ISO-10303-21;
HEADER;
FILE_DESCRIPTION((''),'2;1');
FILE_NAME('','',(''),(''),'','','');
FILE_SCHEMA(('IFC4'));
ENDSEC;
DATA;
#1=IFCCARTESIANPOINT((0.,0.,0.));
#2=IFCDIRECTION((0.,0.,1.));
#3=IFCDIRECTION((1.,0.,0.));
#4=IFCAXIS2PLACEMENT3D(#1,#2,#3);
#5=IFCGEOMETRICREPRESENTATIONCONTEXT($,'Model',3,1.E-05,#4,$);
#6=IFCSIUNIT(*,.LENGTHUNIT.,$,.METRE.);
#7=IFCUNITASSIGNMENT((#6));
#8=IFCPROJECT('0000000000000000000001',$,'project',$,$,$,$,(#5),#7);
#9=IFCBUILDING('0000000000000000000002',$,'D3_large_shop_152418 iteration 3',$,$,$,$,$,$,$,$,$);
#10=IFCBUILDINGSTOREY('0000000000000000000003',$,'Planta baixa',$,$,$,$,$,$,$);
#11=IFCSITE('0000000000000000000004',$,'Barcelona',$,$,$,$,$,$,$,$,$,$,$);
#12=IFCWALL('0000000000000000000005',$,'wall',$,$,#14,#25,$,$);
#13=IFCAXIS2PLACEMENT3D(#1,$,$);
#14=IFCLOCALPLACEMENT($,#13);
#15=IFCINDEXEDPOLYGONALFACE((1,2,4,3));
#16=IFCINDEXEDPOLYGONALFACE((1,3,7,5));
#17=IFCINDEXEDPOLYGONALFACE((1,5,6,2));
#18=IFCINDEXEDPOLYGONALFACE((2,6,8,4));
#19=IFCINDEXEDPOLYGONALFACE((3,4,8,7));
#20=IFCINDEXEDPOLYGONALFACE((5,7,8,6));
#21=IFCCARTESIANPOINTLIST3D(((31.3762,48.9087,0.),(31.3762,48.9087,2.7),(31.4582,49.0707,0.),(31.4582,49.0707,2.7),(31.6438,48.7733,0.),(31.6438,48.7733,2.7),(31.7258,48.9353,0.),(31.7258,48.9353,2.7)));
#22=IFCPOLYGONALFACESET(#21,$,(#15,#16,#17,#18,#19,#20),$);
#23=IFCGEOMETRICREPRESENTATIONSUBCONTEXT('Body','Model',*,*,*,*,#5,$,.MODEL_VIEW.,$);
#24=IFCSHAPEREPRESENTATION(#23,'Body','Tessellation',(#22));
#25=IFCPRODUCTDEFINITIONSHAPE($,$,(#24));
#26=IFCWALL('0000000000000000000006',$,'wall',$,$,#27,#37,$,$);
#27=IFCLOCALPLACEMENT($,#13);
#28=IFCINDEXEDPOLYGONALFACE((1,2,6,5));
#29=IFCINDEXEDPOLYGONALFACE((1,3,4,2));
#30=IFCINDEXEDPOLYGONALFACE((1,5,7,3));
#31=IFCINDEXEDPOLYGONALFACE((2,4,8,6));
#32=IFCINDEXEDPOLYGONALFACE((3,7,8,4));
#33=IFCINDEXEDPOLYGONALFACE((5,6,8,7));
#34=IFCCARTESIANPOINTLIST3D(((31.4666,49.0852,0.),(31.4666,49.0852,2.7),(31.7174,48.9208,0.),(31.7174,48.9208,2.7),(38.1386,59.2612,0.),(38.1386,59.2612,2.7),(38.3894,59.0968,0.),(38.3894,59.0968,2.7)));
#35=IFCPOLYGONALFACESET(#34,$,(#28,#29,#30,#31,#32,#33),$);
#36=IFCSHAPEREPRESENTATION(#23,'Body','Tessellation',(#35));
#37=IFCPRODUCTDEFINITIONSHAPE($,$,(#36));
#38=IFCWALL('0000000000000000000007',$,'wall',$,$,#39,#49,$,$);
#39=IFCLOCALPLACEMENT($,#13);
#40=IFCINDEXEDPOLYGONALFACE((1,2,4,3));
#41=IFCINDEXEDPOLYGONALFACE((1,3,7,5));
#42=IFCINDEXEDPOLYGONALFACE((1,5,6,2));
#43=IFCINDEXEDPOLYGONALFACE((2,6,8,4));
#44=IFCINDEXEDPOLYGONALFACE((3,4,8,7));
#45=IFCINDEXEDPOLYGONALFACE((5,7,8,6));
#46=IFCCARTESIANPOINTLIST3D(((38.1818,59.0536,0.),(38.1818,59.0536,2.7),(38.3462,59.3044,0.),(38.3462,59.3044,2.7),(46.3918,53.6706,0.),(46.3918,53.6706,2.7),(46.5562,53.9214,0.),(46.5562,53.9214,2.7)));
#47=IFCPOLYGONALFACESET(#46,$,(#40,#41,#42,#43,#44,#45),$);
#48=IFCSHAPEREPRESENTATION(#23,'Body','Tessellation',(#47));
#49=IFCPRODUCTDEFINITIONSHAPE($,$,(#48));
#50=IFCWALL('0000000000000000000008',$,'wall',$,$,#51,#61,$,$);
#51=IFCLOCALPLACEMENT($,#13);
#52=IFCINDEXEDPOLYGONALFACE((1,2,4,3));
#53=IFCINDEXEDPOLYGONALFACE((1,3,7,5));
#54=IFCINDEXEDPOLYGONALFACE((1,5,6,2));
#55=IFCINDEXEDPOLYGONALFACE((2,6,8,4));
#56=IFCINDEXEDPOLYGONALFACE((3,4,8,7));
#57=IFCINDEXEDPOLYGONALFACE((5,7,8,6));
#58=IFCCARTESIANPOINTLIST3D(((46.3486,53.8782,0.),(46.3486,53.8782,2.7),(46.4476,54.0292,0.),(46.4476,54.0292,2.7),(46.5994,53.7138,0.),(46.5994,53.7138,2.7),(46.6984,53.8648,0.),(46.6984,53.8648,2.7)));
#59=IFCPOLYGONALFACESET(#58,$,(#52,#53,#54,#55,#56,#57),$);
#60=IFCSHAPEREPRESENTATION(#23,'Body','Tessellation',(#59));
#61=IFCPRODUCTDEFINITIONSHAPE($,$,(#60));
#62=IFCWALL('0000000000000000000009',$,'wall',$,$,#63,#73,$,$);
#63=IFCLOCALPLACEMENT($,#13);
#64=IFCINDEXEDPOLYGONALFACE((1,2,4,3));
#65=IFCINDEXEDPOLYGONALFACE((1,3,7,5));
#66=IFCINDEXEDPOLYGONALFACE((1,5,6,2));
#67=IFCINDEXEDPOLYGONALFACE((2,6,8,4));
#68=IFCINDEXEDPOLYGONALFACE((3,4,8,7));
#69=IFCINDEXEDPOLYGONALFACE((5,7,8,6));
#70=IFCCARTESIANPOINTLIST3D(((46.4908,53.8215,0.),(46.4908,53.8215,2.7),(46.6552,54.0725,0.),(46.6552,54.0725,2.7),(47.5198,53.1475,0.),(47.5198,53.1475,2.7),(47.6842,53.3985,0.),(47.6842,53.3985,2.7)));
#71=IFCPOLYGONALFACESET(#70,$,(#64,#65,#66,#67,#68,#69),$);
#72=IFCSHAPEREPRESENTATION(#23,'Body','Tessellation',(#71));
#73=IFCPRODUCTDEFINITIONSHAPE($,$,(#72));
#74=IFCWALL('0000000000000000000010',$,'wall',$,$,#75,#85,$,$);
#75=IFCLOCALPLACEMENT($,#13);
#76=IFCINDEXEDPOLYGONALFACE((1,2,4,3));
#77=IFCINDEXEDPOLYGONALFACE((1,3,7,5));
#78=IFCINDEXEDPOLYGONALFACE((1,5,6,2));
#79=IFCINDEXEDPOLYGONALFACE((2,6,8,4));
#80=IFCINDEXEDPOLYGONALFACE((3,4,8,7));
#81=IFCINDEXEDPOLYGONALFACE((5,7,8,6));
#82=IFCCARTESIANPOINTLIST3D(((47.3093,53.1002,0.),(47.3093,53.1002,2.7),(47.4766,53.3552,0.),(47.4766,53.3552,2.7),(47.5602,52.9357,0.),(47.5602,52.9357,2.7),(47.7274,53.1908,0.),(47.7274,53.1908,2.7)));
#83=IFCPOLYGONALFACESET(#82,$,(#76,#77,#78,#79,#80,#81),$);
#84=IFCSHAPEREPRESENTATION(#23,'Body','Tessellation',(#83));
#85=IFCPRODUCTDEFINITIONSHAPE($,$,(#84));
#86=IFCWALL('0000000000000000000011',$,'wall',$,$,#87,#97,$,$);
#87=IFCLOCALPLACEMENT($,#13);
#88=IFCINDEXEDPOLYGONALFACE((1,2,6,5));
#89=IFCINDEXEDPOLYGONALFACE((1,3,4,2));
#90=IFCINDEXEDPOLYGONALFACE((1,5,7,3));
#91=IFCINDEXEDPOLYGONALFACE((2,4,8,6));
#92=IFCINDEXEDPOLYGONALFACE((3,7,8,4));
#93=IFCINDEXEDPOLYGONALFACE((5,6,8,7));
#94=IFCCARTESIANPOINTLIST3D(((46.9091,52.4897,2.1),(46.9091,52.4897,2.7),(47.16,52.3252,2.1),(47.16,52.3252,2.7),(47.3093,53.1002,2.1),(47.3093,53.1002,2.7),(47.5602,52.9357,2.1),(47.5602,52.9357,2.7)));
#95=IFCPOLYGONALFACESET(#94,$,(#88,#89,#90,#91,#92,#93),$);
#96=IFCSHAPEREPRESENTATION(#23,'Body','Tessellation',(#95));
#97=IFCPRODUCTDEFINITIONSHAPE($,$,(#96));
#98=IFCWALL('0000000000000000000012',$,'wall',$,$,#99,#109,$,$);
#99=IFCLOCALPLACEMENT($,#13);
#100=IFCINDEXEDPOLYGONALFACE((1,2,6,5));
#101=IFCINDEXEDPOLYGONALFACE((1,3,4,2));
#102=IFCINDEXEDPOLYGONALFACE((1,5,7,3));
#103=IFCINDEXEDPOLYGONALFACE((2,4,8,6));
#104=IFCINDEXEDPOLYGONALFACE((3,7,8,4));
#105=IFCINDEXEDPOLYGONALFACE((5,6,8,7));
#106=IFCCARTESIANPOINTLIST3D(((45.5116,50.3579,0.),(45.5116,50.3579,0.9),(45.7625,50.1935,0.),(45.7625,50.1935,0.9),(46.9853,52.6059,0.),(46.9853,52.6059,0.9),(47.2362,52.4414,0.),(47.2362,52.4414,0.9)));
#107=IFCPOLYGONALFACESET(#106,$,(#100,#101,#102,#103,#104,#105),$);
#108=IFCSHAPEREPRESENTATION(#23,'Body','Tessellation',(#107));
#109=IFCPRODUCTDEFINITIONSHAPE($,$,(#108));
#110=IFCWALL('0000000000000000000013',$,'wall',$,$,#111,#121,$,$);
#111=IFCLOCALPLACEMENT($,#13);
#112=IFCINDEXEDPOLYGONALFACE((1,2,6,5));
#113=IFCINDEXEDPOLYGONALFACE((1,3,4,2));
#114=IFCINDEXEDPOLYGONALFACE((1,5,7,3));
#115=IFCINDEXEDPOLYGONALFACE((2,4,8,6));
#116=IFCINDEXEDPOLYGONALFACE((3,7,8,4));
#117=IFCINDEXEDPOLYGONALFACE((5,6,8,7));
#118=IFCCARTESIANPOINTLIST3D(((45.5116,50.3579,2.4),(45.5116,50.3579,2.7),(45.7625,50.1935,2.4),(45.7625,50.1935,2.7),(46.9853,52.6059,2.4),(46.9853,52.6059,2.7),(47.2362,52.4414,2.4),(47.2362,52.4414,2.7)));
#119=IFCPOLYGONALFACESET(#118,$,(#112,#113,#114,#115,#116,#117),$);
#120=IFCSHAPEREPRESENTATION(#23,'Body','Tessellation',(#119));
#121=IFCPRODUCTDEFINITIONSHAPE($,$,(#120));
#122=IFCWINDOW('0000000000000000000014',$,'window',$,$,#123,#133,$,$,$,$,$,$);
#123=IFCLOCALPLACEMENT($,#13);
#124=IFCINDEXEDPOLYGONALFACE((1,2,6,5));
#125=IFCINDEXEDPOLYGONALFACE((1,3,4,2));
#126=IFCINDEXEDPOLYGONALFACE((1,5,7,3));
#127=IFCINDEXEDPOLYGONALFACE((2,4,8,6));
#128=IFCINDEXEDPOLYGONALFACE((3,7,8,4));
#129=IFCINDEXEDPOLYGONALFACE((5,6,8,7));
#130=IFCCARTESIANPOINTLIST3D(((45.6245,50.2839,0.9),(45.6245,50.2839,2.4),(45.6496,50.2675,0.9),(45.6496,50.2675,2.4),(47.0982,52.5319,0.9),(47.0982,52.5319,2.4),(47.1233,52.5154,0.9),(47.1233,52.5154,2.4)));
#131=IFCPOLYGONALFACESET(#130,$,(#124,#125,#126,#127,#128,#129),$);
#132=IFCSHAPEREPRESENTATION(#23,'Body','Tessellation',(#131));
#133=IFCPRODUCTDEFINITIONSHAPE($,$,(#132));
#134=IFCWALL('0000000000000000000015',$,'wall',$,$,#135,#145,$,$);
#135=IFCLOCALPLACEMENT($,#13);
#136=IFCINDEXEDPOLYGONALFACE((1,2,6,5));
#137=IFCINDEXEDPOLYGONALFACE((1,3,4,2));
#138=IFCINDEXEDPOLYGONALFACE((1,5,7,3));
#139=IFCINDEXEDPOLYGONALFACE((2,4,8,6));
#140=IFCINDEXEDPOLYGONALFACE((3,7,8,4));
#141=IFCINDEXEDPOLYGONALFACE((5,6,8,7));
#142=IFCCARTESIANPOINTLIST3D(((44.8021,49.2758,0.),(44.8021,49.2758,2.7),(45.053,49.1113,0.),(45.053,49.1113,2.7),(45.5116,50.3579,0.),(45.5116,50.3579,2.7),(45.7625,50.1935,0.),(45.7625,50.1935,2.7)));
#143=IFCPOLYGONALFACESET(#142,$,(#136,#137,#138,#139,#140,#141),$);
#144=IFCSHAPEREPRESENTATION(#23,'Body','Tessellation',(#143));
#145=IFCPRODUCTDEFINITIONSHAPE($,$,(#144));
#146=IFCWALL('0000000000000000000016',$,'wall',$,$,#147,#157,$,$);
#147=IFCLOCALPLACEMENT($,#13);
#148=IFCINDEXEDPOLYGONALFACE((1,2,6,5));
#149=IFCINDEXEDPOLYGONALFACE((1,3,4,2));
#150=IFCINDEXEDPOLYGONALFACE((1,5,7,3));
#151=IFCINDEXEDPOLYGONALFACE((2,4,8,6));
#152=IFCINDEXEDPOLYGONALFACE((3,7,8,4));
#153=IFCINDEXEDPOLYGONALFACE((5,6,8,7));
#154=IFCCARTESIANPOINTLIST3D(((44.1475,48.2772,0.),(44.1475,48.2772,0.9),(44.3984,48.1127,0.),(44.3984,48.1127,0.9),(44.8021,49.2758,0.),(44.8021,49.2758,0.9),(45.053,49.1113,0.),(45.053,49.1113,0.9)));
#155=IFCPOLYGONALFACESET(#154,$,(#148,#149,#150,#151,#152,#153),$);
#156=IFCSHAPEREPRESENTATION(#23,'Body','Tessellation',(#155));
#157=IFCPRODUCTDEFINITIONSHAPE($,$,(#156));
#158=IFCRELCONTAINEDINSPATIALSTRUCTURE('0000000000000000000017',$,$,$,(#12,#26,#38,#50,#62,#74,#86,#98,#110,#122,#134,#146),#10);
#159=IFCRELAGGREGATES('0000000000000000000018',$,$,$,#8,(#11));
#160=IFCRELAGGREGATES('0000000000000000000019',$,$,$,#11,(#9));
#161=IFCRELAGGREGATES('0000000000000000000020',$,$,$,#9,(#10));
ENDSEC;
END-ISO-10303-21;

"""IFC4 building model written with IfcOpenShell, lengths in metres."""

from ifc_helpers import new_model, si_unit, frame, origin, origin_with_axes, place, context, subcontext, project, spatial, polyline, outline, extrude, element, save


model = new_model("IFC4")

# Units and contexts
model_context = context("Model", 3, precision=1e-05, world=origin_with_axes())
body_context = subcontext(model_context, "Body", "Model", "MODEL_VIEW")
ifc_project = project(units=[si_unit("LENGTHUNIT", "METRE")], contexts=[model_context])

# Site, building, storey
site = spatial("IfcSite", under=ifc_project, Name="Barcelona")
building = spatial("IfcBuilding", under=site, Name="D3_large_shop_152418 iteration 3")
storey = spatial("IfcBuildingStorey", under=building, Name="Planta baixa")

# Walls
wall_1_placement = place(None, origin_with_axes())
element("IfcWall", 1, at=wall_1_placement, inside=storey, Name="wall", context=body_context, shape_type="SweptSolid", body=[
    extrude(outline(polyline([(31.3762, 48.9087), (31.4582, 49.0707), (31.7258, 48.9353), (31.6438, 48.7733), (31.3762, 48.9087)])), origin(), (0.0, 0.0, 1.0), 2.7),
])
wall_2_placement = place(None, origin_with_axes())
element("IfcWall", 2, at=wall_2_placement, inside=storey, Name="wall", context=body_context, shape_type="SweptSolid", body=[
    extrude(outline(polyline([(31.4666, 49.0852), (38.1386, 59.2612), (38.3894, 59.0968), (31.7174, 48.9208), (31.4666, 49.0852)])), origin(), (0.0, 0.0, 1.0), 2.7),
])
wall_3_placement = place(None, origin_with_axes())
element("IfcWall", 3, at=wall_3_placement, inside=storey, Name="wall", context=body_context, shape_type="SweptSolid", body=[
    extrude(outline(polyline([(38.3462, 59.3044), (46.5562, 53.9214), (46.3918, 53.6706), (38.1818, 59.0536), (38.3462, 59.3044)])), origin(), (0.0, 0.0, 1.0), 2.7),
])
wall_4_placement = place(None, origin_with_axes())
element("IfcWall", 4, at=wall_4_placement, inside=storey, Name="wall", context=body_context, shape_type="SweptSolid", body=[
    extrude(outline(polyline([(46.3486, 53.8782), (46.4476, 54.0292), (46.6984, 53.8648), (46.5994, 53.7138), (46.3486, 53.8782)])), origin(), (0.0, 0.0, 1.0), 2.7),
])
wall_5_placement = place(None, origin_with_axes())
element("IfcWall", 5, at=wall_5_placement, inside=storey, Name="wall", context=body_context, shape_type="SweptSolid", body=[
    extrude(outline(polyline([(46.6552, 54.0725), (47.6842, 53.3985), (47.5198, 53.1475), (46.4908, 53.8215), (46.6552, 54.0725)])), origin(), (0.0, 0.0, 1.0), 2.7),
])
wall_6_placement = place(None, origin_with_axes())
element("IfcWall", 6, at=wall_6_placement, inside=storey, Name="wall", context=body_context, shape_type="SweptSolid", body=[
    extrude(outline(polyline([(47.7274, 53.1908), (47.5602, 52.9357), (47.3093, 53.1002), (47.4766, 53.3552), (47.7274, 53.1908)])), origin(), (0.0, 0.0, 1.0), 2.7),
])
wall_7_placement = place(None, origin_with_axes())
element("IfcWall", 7, at=wall_7_placement, inside=storey, Name="wall", context=body_context, shape_type="SweptSolid", body=[
    extrude(outline(polyline([(47.5602, 52.9357), (47.16, 52.3252), (46.9091, 52.4897), (47.3093, 53.1002), (47.5602, 52.9357)])), frame((0.0, 0.0, 2.1)), (0.0, 0.0, 1.0), 0.6),
])
wall_8_placement = place(None, origin_with_axes())
element("IfcWall", 8, at=wall_8_placement, inside=storey, Name="wall", context=body_context, shape_type="SweptSolid", body=[
    extrude(outline(polyline([(47.2362, 52.4414), (45.7625, 50.1935), (45.5116, 50.3579), (46.9853, 52.6059), (47.2362, 52.4414)])), origin(), (0.0, 0.0, 1.0), 0.9),
])
wall_9_placement = place(None, origin_with_axes())
element("IfcWall", 9, at=wall_9_placement, inside=storey, Name="wall", context=body_context, shape_type="SweptSolid", body=[
    extrude(outline(polyline([(47.2362, 52.4414), (45.7625, 50.1935), (45.5116, 50.3579), (46.9853, 52.6059), (47.2362, 52.4414)])), frame((0.0, 0.0, 2.4)), (0.0, 0.0, 1.0), 0.3),
])

# Window
window_1_placement = place(None, origin_with_axes())
element("IfcWindow", 10, at=window_1_placement, inside=storey, Name="window", context=body_context, shape_type="SweptSolid", body=[
    extrude(outline(polyline([(47.1233, 52.5154), (45.6496, 50.2675), (45.6245, 50.2839), (47.0982, 52.5319), (47.1233, 52.5154)])), frame((0.0, 0.0, 0.9)), (0.0, 0.0, 1.0), 1.5),
])

# Walls
wall_10_placement = place(None, origin_with_axes())
element("IfcWall", 11, at=wall_10_placement, inside=storey, Name="wall", context=body_context, shape_type="SweptSolid", body=[
    extrude(outline(polyline([(45.7625, 50.1935), (45.053, 49.1113), (44.8021, 49.2758), (45.5116, 50.3579), (45.7625, 50.1935)])), origin(), (0.0, 0.0, 1.0), 2.7),
])
wall_11_placement = place(None, origin_with_axes())
element("IfcWall", 12, at=wall_11_placement, inside=storey, Name="wall", context=body_context, shape_type="SweptSolid", body=[
    extrude(outline(polyline([(45.053, 49.1113), (44.3984, 48.1127), (44.1475, 48.2772), (44.8021, 49.2758), (45.053, 49.1113)])), origin(), (0.0, 0.0, 1.0), 0.9),
])

save(model, "model.ifc")
